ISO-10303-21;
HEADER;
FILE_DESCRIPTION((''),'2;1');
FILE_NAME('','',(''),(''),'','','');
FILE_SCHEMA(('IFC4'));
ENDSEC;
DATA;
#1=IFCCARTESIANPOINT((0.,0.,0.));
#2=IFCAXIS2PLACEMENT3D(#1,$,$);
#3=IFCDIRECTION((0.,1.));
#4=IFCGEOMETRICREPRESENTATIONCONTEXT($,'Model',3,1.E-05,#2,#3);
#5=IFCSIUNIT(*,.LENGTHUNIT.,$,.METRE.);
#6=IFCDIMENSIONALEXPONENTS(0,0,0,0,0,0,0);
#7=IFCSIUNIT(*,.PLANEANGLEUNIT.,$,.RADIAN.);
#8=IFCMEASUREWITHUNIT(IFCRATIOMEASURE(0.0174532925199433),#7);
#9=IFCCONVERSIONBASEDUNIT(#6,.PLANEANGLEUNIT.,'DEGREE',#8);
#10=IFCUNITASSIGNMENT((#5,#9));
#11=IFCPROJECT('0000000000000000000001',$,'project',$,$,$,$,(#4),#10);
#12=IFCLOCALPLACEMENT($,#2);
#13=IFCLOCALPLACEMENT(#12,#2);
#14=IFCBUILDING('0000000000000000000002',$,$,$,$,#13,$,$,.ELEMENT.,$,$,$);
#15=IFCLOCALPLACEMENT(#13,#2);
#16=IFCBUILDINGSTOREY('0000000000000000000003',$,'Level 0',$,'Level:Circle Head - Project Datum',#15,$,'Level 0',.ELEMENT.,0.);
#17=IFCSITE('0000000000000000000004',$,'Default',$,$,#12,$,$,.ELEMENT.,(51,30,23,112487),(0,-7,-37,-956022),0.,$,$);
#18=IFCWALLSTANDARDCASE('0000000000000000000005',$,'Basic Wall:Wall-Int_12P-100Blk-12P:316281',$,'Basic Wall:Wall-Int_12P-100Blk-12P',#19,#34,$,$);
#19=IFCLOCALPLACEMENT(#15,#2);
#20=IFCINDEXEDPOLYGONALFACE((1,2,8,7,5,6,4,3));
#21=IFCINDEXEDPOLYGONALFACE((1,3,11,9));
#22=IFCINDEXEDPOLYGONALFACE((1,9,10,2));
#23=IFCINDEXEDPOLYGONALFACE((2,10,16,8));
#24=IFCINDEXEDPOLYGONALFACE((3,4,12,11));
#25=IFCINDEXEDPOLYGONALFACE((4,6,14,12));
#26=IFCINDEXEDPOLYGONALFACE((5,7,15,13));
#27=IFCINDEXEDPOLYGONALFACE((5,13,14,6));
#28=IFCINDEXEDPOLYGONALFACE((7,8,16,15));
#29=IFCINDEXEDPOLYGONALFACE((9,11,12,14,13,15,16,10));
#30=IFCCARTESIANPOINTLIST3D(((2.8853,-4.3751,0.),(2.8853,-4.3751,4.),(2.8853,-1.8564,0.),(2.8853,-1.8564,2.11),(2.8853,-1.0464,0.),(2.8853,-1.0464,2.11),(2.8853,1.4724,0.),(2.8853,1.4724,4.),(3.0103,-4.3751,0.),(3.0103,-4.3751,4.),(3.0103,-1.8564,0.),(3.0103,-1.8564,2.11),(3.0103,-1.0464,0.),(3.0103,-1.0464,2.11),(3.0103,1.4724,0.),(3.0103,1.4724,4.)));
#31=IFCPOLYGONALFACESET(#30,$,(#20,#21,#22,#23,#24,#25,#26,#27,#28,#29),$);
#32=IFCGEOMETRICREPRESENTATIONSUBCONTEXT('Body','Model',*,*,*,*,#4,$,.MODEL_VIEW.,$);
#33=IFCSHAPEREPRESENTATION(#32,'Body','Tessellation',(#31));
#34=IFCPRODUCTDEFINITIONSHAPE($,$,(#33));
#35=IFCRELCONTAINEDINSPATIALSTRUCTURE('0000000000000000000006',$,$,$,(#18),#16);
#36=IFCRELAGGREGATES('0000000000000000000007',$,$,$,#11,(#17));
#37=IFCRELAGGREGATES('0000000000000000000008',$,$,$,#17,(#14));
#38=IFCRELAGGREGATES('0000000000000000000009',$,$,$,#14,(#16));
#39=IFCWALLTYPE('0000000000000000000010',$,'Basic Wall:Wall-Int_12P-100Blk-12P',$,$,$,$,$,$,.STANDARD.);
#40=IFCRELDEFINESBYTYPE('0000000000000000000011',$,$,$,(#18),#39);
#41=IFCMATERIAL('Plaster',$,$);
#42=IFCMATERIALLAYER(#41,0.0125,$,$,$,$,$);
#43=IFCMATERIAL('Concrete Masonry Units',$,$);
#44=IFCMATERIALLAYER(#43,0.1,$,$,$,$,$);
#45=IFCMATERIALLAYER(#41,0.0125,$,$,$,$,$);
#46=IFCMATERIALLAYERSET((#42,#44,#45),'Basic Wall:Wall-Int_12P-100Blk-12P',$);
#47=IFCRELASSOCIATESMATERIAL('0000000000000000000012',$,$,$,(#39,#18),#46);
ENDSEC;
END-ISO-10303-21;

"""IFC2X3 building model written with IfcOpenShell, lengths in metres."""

from ifc_helpers import new_model, entity, si_unit, converted_unit, direction, frame, frame_2d, origin, place, context, subcontext, project, spatial, rectangle, extrude, material, layer, layer_set, layer_usage, type_object, element, save


model = new_model("IFC2X3")

# Units and contexts
model_context = context("Model", 3, precision=1e-05, world=origin(), true_north=direction((0.0, 1.0)))
body_context = subcontext(model_context, "Body", "Model", "MODEL_VIEW")
ifc_project = project(units=[si_unit("LENGTHUNIT", "METRE"), converted_unit("PLANEANGLEUNIT", "DEGREE", entity("IfcRatioMeasure", 0.0174532925199433), si_unit("PLANEANGLEUNIT", "RADIAN"), dimensions=[0, 0, 0, 0, 0, 0, 0])], contexts=[model_context])

# Site, building, storey
site_placement = place(None, origin())
site = spatial("IfcSite", under=ifc_project, at=site_placement, Name="Default", CompositionType="ELEMENT", RefLatitude=(51, 30, 23, 112487), RefLongitude=(0, -7, -37, -956022), RefElevation=0.0)
building_placement = place(site_placement, origin())
building = spatial("IfcBuilding", under=site, at=building_placement, CompositionType="ELEMENT")
storey_placement = place(building_placement, origin())
storey = spatial("IfcBuildingStorey", under=building, at=storey_placement, Name="Level 0", ObjectType="Level:Circle Head - Project Datum", LongName="Level 0", CompositionType="ELEMENT", Elevation=0.0)

# Shared definitions
ifc_material_1 = material(Name="Plaster")

# Wall, opening
ifc_layer_1 = layer(ifc_material_1, 0.0125)
ifc_material_2 = material(Name="Concrete Masonry Units")
ifc_layer_2 = layer(ifc_material_2, 0.1)
ifc_layer_3 = layer(ifc_material_1, 0.0125)
ifc_layer_set_1 = layer_set([ifc_layer_1, ifc_layer_2, ifc_layer_3], Name="Basic Wall:Wall-Int_12P-100Blk-12P")
wall_type_1 = type_object("IfcWallType", Name="Basic Wall:Wall-Int_12P-100Blk-12P", PredefinedType="STANDARD", material=ifc_layer_set_1)
ifc_layer_usage_1 = layer_usage(ifc_layer_set_1, "AXIS2", "NEGATIVE", 0.0625)
wall_1_placement = place(storey_placement, frame((2.9478, 1.4724, 0.0), z_axis=(0.0, 0.0, 1.0), x_axis=(0.0, -1.0, 0.0)))
wall_1 = element("IfcWallStandardCase", 1, at=wall_1_placement, inside=storey, type_object=wall_type_1, material=ifc_layer_usage_1, Name="Basic Wall:Wall-Int_12P-100Blk-12P:316281", ObjectType="Basic Wall:Wall-Int_12P-100Blk-12P", context=body_context, shape_type="SweptSolid", body=[
    extrude(rectangle(XDim=5.8475, YDim=0.125, at=frame_2d((2.9238, 0.0), x_axis=(-1.0, 0.0))), origin(), (0.0, 0.0, 1.0), 4.0),
])
opening_1_placement = place(wall_1_placement, frame((3.3287, 0.0625, 0.0)))
element("IfcOpeningElement", 2, at=opening_1_placement, cuts=wall_1, ObjectType="Opening", context=body_context, shape_type="SweptSolid", body=[
    extrude(rectangle(XDim=2.11, YDim=0.81, at=frame_2d((1.055, 0.405), x_axis=(1.0, 0.0))), frame((0.0, 0.0, 0.0), z_axis=(0.0, -1.0, 0.0), x_axis=(0.0, 0.0, 1.0)), (0.0, 0.0, 1.0), 0.125),
])

save(model, "model.ifc")
